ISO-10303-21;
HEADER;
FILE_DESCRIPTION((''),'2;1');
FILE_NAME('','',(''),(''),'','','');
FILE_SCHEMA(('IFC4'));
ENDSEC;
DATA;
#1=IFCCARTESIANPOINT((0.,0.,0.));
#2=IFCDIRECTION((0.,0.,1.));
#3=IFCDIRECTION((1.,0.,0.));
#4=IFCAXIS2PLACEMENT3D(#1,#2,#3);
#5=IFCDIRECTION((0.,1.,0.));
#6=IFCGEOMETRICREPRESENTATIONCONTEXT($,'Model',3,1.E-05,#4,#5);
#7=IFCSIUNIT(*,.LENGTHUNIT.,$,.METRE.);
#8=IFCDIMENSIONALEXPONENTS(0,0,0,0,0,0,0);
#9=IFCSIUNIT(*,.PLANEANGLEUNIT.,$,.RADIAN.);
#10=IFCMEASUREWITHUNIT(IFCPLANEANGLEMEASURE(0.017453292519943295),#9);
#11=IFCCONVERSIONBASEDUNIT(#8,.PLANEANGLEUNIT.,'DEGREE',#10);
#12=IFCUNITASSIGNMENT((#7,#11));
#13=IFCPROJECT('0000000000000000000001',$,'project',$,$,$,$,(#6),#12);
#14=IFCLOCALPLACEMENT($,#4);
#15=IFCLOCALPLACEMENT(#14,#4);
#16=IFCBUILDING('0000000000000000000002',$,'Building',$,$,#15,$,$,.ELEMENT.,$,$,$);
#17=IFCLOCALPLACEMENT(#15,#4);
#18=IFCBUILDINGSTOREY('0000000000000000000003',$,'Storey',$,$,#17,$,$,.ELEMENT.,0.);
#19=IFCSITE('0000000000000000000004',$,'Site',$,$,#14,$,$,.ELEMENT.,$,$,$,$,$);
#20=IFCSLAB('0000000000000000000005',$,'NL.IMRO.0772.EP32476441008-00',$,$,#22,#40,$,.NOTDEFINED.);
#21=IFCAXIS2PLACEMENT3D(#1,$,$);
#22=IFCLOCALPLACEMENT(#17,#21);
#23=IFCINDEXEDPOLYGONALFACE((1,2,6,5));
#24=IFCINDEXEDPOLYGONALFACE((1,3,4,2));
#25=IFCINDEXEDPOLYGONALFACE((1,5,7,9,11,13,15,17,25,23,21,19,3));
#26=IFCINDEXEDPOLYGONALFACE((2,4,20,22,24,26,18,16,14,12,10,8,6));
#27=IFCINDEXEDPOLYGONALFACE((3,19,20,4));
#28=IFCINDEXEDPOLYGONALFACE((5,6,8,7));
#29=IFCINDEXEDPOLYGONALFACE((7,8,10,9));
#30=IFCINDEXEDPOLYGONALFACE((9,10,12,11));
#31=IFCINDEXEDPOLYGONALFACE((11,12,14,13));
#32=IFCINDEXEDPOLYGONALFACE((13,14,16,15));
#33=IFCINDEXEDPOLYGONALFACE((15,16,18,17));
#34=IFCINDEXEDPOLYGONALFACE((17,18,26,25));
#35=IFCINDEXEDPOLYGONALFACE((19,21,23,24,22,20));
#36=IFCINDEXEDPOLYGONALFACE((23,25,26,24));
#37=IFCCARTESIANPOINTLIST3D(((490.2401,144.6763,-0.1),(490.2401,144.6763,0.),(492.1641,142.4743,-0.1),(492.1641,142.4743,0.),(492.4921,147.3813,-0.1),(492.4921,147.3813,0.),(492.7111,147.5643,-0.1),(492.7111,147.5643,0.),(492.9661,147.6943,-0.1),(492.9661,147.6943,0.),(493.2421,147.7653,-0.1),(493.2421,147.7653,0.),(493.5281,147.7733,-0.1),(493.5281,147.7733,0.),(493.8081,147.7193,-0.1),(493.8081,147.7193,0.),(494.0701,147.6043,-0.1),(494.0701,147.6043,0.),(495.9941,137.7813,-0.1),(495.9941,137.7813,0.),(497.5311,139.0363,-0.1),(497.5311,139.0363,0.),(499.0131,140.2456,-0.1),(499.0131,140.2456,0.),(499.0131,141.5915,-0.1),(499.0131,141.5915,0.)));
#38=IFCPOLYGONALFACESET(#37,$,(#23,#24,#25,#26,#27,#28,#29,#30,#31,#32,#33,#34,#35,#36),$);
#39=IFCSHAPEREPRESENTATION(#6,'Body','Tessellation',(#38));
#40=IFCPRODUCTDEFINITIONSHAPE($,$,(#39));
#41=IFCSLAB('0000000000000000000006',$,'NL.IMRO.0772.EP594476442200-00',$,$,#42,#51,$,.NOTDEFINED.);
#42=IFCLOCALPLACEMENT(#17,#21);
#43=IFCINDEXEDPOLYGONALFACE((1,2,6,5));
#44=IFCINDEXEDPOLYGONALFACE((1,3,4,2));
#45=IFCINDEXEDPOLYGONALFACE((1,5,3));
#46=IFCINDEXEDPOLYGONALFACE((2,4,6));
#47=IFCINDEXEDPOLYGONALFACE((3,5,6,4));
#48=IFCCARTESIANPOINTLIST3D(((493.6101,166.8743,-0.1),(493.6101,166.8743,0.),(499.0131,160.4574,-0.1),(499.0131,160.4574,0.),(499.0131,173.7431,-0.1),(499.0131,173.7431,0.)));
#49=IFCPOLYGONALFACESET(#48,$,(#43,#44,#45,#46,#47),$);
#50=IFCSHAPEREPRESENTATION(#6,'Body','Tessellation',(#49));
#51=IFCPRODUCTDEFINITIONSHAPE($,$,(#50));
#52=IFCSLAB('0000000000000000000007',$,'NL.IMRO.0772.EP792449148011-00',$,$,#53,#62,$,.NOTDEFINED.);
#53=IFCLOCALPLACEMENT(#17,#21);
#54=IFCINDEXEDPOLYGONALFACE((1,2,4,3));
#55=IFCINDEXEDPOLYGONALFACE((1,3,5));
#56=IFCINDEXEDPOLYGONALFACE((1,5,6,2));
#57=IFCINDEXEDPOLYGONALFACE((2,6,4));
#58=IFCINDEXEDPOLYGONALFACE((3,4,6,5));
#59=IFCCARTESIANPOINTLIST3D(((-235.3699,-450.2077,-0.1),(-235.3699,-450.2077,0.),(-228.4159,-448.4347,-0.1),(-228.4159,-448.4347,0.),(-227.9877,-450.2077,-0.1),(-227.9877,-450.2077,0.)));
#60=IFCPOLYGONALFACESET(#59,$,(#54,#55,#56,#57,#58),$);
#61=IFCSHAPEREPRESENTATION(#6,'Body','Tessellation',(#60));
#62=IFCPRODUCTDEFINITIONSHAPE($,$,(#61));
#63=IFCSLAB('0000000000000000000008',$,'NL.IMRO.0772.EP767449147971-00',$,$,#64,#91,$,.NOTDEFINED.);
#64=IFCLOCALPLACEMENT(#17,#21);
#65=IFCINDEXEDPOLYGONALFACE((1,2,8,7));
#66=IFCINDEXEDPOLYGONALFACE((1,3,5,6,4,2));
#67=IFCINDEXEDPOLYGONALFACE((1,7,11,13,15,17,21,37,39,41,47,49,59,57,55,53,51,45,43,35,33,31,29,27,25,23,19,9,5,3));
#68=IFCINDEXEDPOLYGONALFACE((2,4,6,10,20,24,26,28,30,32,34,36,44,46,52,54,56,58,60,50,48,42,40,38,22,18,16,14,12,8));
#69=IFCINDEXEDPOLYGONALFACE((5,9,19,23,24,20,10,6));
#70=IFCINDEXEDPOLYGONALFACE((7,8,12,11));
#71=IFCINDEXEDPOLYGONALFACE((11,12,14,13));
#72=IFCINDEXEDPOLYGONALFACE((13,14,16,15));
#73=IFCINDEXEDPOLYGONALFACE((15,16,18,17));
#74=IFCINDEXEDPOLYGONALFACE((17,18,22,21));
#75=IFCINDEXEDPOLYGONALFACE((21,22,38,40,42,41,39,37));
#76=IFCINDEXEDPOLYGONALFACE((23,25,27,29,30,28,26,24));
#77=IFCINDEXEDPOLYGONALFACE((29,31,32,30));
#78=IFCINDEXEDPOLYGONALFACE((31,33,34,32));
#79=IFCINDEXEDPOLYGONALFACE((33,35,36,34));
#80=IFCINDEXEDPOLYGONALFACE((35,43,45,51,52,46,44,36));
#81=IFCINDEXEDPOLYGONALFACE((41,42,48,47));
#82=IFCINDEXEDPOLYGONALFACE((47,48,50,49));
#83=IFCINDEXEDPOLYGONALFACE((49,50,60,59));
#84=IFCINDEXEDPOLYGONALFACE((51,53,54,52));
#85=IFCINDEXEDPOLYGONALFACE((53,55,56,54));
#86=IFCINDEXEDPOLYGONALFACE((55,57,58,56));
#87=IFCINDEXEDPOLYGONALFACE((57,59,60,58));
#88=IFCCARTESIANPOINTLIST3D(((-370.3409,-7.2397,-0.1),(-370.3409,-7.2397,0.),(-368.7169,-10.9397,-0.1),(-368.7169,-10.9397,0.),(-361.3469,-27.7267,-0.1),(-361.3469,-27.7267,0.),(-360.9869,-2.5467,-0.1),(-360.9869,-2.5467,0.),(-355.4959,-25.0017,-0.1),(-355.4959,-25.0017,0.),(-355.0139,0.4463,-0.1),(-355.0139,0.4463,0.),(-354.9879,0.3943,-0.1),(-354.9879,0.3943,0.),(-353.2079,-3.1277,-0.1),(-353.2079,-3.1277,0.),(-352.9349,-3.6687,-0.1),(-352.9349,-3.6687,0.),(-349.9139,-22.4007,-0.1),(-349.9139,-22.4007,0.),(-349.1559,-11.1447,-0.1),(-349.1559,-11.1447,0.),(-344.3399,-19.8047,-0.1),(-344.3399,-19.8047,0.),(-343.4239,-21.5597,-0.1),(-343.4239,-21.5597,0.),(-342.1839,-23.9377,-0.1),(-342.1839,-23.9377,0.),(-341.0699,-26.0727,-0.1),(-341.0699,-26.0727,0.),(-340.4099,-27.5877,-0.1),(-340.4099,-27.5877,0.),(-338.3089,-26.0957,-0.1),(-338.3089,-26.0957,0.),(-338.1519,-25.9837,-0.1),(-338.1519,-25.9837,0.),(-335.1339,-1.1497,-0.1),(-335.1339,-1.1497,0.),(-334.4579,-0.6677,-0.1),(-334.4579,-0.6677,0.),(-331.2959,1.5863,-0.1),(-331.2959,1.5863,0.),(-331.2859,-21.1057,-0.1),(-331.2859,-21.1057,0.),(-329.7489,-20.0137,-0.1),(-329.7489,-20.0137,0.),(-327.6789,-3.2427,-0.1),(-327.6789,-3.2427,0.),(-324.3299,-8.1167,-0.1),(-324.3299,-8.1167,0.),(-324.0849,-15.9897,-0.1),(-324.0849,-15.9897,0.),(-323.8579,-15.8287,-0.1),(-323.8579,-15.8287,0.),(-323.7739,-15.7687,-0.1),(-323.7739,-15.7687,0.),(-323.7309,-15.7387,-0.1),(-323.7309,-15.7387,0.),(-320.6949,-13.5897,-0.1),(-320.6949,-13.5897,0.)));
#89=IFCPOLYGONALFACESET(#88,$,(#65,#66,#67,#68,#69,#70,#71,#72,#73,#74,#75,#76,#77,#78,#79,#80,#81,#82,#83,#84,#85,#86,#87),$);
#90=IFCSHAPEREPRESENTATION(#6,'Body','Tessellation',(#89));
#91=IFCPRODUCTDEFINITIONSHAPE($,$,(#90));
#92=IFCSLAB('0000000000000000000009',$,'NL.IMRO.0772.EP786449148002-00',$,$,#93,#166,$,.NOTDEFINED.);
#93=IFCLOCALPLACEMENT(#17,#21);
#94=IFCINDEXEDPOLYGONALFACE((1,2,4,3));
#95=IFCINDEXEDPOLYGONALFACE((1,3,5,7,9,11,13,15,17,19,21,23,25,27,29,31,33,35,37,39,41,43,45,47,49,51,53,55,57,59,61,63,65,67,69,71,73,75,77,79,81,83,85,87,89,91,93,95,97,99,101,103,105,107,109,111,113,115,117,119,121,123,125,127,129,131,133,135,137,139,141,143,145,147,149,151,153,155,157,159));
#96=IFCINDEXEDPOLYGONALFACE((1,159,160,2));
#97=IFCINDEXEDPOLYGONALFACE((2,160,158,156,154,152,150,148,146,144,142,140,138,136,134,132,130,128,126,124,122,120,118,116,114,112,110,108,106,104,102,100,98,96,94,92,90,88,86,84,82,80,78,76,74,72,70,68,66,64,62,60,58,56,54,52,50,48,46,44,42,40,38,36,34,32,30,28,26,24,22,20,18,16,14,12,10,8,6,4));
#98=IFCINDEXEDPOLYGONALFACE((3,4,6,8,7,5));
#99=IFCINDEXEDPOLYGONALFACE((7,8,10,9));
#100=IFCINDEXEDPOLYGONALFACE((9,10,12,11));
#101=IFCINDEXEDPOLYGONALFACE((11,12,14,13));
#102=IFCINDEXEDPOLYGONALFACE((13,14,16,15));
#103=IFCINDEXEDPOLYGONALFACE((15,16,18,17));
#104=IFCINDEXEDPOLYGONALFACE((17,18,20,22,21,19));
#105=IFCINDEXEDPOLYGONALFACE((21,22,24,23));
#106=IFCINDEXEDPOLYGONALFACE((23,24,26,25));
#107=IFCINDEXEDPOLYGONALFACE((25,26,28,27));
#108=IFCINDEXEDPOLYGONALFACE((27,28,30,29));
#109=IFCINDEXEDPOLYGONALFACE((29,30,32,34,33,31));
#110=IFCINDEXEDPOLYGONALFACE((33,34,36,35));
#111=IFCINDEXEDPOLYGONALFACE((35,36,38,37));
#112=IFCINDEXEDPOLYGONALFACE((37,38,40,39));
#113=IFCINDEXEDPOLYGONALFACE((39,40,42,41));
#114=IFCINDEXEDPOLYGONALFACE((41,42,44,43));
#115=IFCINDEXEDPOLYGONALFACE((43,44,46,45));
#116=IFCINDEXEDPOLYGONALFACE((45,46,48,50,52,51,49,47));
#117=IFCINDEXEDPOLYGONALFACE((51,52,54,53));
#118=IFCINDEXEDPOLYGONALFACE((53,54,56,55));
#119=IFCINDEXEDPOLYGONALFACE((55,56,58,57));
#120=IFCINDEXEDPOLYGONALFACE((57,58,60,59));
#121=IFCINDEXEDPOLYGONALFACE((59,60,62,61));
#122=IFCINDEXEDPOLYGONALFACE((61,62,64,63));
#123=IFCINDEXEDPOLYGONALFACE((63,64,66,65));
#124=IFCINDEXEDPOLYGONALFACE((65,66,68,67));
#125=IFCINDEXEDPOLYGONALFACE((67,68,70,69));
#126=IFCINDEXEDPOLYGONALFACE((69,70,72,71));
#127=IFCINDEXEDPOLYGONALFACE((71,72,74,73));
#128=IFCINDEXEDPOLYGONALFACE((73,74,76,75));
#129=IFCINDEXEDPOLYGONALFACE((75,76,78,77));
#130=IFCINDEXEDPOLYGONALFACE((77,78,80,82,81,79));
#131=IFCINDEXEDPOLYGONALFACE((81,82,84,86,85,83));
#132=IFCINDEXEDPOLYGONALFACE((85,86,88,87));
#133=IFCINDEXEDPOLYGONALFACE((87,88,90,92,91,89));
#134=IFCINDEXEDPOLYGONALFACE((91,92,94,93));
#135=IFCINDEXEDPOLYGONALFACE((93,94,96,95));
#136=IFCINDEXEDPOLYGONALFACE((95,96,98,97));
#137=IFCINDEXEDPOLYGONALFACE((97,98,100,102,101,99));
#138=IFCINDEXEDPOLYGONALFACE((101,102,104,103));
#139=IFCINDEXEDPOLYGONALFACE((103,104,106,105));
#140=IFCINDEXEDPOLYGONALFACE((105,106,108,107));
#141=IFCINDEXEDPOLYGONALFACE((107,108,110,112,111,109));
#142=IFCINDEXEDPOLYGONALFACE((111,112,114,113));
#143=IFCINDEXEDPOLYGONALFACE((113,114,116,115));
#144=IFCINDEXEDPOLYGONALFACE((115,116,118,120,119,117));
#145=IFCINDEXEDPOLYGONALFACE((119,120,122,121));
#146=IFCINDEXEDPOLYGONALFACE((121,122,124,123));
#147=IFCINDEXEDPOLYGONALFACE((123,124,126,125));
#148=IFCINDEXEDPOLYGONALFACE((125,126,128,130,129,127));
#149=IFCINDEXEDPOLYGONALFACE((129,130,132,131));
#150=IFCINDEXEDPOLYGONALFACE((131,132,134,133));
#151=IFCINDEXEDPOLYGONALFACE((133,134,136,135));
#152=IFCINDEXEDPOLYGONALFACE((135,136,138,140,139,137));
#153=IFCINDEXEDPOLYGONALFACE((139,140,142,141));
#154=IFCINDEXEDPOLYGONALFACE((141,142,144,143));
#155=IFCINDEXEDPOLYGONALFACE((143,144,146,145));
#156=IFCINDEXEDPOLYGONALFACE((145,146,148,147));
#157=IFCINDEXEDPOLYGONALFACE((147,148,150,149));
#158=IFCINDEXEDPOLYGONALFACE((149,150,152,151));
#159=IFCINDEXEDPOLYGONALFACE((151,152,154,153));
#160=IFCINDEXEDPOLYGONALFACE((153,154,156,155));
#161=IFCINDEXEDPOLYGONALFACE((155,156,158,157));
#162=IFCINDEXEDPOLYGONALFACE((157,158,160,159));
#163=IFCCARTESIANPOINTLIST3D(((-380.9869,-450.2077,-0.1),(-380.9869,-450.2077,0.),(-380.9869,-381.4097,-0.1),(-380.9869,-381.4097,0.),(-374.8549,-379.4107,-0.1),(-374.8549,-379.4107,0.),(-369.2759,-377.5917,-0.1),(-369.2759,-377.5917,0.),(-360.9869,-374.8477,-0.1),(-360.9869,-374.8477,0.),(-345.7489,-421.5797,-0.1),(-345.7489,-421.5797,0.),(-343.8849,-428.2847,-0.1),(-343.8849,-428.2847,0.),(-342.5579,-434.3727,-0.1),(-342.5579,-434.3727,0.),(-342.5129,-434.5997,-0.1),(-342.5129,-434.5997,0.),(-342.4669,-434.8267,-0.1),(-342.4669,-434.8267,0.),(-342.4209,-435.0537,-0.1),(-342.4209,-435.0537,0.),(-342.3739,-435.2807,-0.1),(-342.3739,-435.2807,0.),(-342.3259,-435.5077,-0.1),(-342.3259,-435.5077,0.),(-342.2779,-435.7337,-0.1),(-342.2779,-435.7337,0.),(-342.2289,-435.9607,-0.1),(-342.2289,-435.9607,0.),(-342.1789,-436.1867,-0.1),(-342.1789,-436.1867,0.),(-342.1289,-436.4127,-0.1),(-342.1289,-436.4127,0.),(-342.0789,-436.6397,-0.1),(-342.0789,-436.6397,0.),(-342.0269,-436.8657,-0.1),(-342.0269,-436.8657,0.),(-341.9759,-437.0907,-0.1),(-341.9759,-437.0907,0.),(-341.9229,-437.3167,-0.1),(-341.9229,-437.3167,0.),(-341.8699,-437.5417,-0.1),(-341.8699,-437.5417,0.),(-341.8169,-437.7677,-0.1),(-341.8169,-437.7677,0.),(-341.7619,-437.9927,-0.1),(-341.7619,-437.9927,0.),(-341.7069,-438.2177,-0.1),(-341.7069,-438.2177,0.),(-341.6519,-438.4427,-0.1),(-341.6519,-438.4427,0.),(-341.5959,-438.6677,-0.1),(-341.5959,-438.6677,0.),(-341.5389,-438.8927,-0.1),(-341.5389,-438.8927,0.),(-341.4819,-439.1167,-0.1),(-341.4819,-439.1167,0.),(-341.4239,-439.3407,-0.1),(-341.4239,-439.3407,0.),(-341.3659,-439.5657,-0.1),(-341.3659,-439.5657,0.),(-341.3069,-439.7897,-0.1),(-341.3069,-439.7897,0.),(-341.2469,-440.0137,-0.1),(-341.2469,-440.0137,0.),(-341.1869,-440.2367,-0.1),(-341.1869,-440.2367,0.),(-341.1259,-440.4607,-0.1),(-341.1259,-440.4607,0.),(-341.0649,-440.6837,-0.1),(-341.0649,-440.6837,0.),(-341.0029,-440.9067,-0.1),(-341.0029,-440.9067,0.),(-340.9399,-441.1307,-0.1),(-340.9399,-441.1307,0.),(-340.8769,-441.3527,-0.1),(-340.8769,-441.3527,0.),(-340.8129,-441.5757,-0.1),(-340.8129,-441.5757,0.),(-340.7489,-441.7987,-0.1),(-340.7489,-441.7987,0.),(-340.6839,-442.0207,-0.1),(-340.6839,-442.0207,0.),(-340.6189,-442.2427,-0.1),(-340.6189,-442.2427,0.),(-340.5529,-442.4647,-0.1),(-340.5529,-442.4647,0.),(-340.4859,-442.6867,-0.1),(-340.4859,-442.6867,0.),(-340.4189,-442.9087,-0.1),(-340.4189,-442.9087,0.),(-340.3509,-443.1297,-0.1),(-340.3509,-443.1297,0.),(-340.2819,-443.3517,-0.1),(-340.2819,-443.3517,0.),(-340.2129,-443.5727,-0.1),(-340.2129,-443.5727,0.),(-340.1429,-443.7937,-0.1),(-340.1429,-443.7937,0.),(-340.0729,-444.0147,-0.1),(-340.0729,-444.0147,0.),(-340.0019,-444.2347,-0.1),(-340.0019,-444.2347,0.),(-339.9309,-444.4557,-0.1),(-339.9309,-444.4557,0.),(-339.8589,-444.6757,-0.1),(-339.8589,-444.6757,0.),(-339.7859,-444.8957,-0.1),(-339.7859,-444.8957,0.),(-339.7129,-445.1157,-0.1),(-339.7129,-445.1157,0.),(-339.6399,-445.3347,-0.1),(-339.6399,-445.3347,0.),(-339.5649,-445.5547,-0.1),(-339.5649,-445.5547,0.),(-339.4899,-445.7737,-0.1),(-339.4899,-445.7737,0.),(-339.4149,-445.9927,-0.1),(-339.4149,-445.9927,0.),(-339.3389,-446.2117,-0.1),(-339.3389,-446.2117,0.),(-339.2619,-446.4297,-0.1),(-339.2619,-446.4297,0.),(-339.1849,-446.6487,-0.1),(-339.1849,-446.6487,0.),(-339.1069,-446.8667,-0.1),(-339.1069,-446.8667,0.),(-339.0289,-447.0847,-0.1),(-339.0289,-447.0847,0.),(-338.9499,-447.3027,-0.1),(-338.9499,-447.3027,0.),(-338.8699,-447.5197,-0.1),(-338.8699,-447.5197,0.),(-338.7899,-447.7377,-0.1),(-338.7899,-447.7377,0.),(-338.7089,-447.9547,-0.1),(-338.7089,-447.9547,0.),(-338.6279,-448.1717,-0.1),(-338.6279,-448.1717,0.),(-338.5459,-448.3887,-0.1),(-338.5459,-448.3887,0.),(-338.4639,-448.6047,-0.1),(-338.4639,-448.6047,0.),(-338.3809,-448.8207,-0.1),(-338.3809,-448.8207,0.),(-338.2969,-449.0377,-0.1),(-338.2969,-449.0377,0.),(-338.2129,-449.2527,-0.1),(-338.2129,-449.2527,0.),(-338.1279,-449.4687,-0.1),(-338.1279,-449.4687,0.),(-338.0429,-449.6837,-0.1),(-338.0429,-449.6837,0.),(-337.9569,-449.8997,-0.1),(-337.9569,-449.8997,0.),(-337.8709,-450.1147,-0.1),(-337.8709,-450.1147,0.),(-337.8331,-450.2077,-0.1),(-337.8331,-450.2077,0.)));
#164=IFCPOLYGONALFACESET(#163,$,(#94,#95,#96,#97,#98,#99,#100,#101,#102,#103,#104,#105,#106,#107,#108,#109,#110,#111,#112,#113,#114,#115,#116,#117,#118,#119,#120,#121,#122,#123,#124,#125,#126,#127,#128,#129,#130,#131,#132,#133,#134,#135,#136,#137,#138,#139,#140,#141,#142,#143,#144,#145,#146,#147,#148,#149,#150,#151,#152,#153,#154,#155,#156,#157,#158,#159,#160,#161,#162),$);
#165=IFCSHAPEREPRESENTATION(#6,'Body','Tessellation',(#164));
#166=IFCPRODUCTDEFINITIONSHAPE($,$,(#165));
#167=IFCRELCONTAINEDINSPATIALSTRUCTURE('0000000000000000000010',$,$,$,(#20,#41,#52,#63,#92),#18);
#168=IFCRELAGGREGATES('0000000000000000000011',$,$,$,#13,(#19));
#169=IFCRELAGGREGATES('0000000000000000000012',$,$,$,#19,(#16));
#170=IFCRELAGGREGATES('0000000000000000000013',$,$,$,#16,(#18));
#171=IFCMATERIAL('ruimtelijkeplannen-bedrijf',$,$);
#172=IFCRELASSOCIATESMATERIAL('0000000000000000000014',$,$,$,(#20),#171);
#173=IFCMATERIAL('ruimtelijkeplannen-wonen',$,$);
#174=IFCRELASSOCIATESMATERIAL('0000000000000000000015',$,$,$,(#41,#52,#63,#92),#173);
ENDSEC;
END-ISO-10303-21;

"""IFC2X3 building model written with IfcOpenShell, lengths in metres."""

from ifc_helpers import new_model, entity, si_unit, converted_unit, direction, frame, origin_with_axes, place, context, project, spatial, polyline, outline, extrude, material, element, save


model = new_model("IFC2X3")

# Units and contexts
model_context = context("Model", 3, precision=1e-05, world=origin_with_axes(), true_north=direction((0.0, 1.0, 0.0)))
ifc_project = project(units=[si_unit("LENGTHUNIT", "METRE"), converted_unit("PLANEANGLEUNIT", "DEGREE", entity("IfcPlaneAngleMeasure", 0.017453292519943295), si_unit("PLANEANGLEUNIT", "RADIAN"), dimensions=[0, 0, 0, 0, 0, 0, 0])], contexts=[model_context])

# Site, building, storey
site_placement = place(None, origin_with_axes())
site = spatial("IfcSite", under=ifc_project, at=site_placement, Name="Site", CompositionType="ELEMENT")
building_placement = place(site_placement, origin_with_axes())
building = spatial("IfcBuilding", under=site, at=building_placement, Name="Building", CompositionType="ELEMENT")
storey_placement = place(building_placement, origin_with_axes())
storey = spatial("IfcBuildingStorey", under=building, at=storey_placement, Name="Storey", CompositionType="ELEMENT", Elevation=0.0)

# Slabs
ifc_material_1 = material(Name="ruimtelijkeplannen-bedrijf")
slab_1_placement = place(storey_placement, frame((0.0, 0.0, -0.1), z_axis=(0.0, 0.0, 1.0), x_axis=(1.0, 0.0, 0.0)))
element("IfcSlab", 1, at=slab_1_placement, inside=storey, material=ifc_material_1, Name="NL.IMRO.0772.EP32476441008-00", PredefinedType="NOTDEFINED", context=model_context, shape_type="SweptSolid", body=[
    extrude(outline(polyline([(497.5311, 139.0363), (495.9941, 137.7813), (492.1641, 142.4743), (490.2401, 144.6763), (492.4921, 147.3813), (492.7111, 147.5643), (492.9661, 147.6943), (493.2421, 147.7653), (493.5281, 147.7733), (493.8081, 147.7193), (494.0701, 147.6043), (499.0131, 141.5915), (499.0131, 140.2456), (497.5311, 139.0363)])), origin_with_axes(), (0.0, 0.0, 1.0), 0.1),
])
ifc_material_2 = material(Name="ruimtelijkeplannen-wonen")
slab_2_placement = place(storey_placement, frame((0.0, 0.0, -0.1), z_axis=(0.0, 0.0, 1.0), x_axis=(1.0, 0.0, 0.0)))
element("IfcSlab", 2, at=slab_2_placement, inside=storey, material=ifc_material_2, Name="NL.IMRO.0772.EP594476442200-00", PredefinedType="NOTDEFINED", context=model_context, shape_type="SweptSolid", body=[
    extrude(outline(polyline([(493.6101, 166.8743), (499.0131, 173.7431), (499.0131, 160.4574), (493.6101, 166.8743)])), origin_with_axes(), (0.0, 0.0, 1.0), 0.1),
])
slab_3_placement = place(storey_placement, frame((0.0, 0.0, -0.1), z_axis=(0.0, 0.0, 1.0), x_axis=(1.0, 0.0, 0.0)))
element("IfcSlab", 3, at=slab_3_placement, inside=storey, material=ifc_material_2, Name="NL.IMRO.0772.EP792449148011-00", PredefinedType="NOTDEFINED", context=model_context, shape_type="SweptSolid", body=[
    extrude(outline(polyline([(-228.4159, -448.4347), (-227.9877, -450.2077), (-235.3699, -450.2077), (-228.4159, -448.4347)])), origin_with_axes(), (0.0, 0.0, 1.0), 0.1),
])
slab_4_placement = place(storey_placement, frame((0.0, 0.0, -0.1), z_axis=(0.0, 0.0, 1.0), x_axis=(1.0, 0.0, 0.0)))
element("IfcSlab", 4, at=slab_4_placement, inside=storey, material=ifc_material_2, Name="NL.IMRO.0772.EP767449147971-00", PredefinedType="NOTDEFINED", context=model_context, shape_type="SweptSolid", body=[
    extrude(outline(polyline([(-368.7169, -10.9397), (-370.3409, -7.2397), (-360.9869, -2.5467), (-355.0139, 0.4463), (-354.9879, 0.3943), (-353.2079, -3.1277), (-352.9349, -3.6687), (-349.1559, -11.1447), (-335.1339, -1.1497), (-334.4579, -0.6677), (-331.2959, 1.5863), (-327.6789, -3.2427), (-324.3299, -8.1167), (-320.6949, -13.5897), (-323.7309, -15.7387), (-323.7739, -15.7687), (-323.8579, -15.8287), (-324.0849, -15.9897), (-329.7489, -20.0137), (-331.2859, -21.1057), (-338.1519, -25.9837), (-338.3089, -26.0957), (-340.4099, -27.5877), (-341.0699, -26.0727), (-342.1839, -23.9377), (-343.4239, -21.5597), (-344.3399, -19.8047), (-349.9139, -22.4007), (-355.4959, -25.0017), (-361.3469, -27.7267), (-368.7169, -10.9397)])), origin_with_axes(), (0.0, 0.0, 1.0), 0.1),
])
slab_5_placement = place(storey_placement, frame((0.0, 0.0, -0.1), z_axis=(0.0, 0.0, 1.0), x_axis=(1.0, 0.0, 0.0)))
element("IfcSlab", 5, at=slab_5_placement, inside=storey, material=ifc_material_2, Name="NL.IMRO.0772.EP786449148002-00", PredefinedType="NOTDEFINED", context=model_context, shape_type="SweptSolid", body=[
    extrude(outline(polyline([(-374.8549, -379.4107), (-369.2759, -377.5917), (-360.9869, -374.8477), (-345.7489, -421.5797), (-343.8849, -428.2847), (-342.5579, -434.3727), (-342.5129, -434.5997), (-342.4669, -434.8267), (-342.4209, -435.0537), (-342.3739, -435.2807), (-342.3259, -435.5077), (-342.2779, -435.7337), (-342.2289, -435.9607), (-342.1789, -436.1867), (-342.1289, -436.4127), (-342.0789, -436.6397), (-342.0269, -436.8657), (-341.9759, -437.0907), (-341.9229, -437.3167), (-341.8699, -437.5417), (-341.8169, -437.7677), (-341.7619, -437.9927), (-341.7069, -438.2177), (-341.6519, -438.4427), (-341.5959, -438.6677), (-341.5389, -438.8927), (-341.4819, -439.1167), (-341.4239, -439.3407), (-341.3659, -439.5657), (-341.3069, -439.7897), (-341.2469, -440.0137), (-341.1869, -440.2367), (-341.1259, -440.4607), (-341.0649, -440.6837), (-341.0029, -440.9067), (-340.9399, -441.1307), (-340.8769, -441.3527), (-340.8129, -441.5757), (-340.7489, -441.7987), (-340.6839, -442.0207), (-340.6189, -442.2427), (-340.5529, -442.4647), (-340.4859, -442.6867), (-340.4189, -442.9087), (-340.3509, -443.1297), (-340.2819, -443.3517), (-340.2129, -443.5727), (-340.1429, -443.7937), (-340.0729, -444.0147), (-340.0019, -444.2347), (-339.9309, -444.4557), (-339.8589, -444.6757), (-339.7859, -444.8957), (-339.7129, -445.1157), (-339.6399, -445.3347), (-339.5649, -445.5547), (-339.4899, -445.7737), (-339.4149, -445.9927), (-339.3389, -446.2117), (-339.2619, -446.4297), (-339.1849, -446.6487), (-339.1069, -446.8667), (-339.0289, -447.0847), (-338.9499, -447.3027), (-338.8699, -447.5197), (-338.7899, -447.7377), (-338.7089, -447.9547), (-338.6279, -448.1717), (-338.5459, -448.3887), (-338.4639, -448.6047), (-338.3809, -448.8207), (-338.2969, -449.0377), (-338.2129, -449.2527), (-338.1279, -449.4687), (-338.0429, -449.6837), (-337.9569, -449.8997), (-337.8709, -450.1147), (-337.8331, -450.2077), (-380.9869, -450.2077), (-380.9869, -381.4097), (-374.8549, -379.4107)])), origin_with_axes(), (0.0, 0.0, 1.0), 0.1),
])

save(model, "model.ifc")
